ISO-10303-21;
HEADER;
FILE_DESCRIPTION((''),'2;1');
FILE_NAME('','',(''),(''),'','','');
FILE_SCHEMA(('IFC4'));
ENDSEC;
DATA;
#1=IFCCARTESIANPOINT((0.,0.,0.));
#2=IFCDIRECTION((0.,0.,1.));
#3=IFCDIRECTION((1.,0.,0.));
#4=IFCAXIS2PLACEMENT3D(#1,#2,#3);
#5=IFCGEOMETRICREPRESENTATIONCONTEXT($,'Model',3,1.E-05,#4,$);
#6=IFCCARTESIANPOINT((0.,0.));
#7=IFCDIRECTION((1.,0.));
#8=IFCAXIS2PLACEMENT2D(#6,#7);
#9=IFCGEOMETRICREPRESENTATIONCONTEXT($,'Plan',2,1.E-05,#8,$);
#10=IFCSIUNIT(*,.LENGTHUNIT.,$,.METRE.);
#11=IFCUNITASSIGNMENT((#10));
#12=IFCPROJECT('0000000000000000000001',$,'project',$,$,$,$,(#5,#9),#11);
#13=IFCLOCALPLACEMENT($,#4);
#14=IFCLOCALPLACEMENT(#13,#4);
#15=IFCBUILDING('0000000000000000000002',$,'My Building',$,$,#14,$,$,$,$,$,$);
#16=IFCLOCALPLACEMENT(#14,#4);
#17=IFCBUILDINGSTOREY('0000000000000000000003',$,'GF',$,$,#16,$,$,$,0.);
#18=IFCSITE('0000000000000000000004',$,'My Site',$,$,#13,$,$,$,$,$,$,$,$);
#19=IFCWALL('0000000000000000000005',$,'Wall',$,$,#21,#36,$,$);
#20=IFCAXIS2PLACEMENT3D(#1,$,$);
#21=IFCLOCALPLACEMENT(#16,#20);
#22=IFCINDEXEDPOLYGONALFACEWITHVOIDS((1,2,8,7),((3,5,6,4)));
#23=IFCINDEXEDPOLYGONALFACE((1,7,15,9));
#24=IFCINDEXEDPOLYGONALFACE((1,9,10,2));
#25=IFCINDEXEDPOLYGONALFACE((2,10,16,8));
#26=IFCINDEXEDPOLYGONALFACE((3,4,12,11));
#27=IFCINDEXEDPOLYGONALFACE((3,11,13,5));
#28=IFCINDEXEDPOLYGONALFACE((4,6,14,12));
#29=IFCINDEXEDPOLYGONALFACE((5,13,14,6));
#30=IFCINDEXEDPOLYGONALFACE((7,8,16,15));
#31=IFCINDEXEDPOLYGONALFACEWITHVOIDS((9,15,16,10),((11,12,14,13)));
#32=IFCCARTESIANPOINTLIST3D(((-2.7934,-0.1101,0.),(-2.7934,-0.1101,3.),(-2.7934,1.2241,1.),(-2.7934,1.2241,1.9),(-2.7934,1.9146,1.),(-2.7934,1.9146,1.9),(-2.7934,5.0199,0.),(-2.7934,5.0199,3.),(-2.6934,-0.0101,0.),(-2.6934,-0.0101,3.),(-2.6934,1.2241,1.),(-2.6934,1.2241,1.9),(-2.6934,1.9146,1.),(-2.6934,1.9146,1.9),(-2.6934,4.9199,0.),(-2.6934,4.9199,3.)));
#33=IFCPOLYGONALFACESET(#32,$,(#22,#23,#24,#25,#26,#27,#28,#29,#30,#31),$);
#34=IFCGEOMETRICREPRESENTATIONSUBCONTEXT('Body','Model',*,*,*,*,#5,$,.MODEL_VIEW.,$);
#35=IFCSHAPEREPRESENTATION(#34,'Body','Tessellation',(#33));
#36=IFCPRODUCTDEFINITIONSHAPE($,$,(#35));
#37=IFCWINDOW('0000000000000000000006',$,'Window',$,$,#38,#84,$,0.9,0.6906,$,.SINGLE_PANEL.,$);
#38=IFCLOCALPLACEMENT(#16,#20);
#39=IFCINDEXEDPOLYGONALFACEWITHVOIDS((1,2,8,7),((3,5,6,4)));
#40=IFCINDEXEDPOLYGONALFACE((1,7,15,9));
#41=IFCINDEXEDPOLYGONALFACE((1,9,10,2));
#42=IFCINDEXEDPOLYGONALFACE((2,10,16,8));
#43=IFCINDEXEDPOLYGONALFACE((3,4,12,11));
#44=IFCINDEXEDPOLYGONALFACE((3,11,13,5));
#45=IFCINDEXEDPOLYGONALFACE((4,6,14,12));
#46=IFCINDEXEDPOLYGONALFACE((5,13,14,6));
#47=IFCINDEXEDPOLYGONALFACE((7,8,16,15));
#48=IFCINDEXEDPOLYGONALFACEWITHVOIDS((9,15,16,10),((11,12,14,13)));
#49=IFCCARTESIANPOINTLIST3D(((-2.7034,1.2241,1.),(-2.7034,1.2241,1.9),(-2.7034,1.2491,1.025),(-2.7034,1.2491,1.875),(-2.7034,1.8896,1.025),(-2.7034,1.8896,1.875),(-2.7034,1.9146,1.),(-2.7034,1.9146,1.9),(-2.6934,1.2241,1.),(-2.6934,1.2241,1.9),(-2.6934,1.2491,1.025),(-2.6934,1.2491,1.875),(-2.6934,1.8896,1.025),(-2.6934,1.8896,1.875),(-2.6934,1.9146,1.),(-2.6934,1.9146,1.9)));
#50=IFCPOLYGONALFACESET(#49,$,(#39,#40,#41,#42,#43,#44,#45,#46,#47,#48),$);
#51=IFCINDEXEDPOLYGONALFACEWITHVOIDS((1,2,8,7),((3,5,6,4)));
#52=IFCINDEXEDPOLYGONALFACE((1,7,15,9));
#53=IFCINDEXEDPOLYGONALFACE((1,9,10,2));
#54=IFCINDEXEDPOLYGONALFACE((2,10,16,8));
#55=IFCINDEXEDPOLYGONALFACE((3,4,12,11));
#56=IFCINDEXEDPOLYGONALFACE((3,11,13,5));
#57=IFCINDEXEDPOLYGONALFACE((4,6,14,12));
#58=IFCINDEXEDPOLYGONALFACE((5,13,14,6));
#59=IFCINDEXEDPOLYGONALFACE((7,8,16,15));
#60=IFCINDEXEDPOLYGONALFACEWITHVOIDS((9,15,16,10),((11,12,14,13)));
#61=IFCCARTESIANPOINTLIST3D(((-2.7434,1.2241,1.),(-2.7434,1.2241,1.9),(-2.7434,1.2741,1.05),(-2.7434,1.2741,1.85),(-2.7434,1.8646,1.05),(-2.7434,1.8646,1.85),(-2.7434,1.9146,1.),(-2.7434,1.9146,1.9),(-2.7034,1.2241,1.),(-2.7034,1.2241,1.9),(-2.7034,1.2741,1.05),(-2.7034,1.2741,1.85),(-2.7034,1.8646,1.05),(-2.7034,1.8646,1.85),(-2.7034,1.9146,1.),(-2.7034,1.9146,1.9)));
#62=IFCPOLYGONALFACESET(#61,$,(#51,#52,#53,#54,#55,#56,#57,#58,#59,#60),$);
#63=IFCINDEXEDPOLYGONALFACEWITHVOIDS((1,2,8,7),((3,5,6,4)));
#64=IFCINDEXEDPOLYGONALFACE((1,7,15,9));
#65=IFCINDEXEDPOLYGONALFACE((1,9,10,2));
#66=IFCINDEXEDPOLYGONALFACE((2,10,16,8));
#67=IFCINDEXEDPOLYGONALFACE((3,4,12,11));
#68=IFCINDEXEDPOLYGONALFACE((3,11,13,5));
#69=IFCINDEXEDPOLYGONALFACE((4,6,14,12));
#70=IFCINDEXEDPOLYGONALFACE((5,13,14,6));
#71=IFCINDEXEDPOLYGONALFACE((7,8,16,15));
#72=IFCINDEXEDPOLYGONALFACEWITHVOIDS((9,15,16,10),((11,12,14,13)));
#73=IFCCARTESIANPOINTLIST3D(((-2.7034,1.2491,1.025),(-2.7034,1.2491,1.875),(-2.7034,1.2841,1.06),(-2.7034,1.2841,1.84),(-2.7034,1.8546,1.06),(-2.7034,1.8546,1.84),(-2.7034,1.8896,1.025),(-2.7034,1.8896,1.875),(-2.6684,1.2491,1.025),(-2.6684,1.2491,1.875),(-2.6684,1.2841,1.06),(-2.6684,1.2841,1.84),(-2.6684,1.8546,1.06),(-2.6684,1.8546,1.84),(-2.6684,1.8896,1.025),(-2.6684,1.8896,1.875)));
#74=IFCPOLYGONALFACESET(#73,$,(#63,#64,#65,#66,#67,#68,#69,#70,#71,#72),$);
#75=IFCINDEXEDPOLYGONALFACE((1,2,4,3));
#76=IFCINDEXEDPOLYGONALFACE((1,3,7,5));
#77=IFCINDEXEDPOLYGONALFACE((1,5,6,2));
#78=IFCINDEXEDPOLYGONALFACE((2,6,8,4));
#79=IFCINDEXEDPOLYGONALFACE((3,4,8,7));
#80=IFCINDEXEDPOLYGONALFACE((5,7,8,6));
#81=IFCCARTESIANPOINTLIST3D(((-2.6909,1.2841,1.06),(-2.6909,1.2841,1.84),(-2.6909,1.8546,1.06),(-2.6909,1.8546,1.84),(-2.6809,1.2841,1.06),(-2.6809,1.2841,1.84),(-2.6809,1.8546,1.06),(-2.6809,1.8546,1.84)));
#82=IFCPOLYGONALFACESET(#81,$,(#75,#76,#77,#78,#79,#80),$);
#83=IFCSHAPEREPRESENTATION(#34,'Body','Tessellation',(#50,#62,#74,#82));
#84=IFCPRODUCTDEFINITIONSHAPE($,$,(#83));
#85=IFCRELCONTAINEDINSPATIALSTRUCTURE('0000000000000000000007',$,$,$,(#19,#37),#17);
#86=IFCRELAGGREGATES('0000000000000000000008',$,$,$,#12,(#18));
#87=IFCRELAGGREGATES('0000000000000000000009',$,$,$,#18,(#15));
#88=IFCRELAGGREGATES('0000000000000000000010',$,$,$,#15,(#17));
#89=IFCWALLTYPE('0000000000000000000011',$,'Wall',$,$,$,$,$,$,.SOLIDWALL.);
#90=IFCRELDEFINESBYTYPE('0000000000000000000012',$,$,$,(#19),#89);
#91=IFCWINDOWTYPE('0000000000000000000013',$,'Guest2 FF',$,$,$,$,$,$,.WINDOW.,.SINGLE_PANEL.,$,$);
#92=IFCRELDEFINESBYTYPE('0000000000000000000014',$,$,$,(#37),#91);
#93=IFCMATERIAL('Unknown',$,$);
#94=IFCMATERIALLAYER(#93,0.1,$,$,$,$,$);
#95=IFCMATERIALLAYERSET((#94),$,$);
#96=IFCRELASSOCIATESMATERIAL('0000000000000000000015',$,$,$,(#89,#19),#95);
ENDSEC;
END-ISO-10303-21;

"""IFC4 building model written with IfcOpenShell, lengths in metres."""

from ifc_helpers import new_model, entity, si_unit, frame, origin_with_axes, origin_2d_with_axis, place, context, subcontext, project, spatial, line, indexed_curve, outline, extrude, shape, source, transform, mapped, material, layer, layer_set, layer_usage, type_object, type_shapes, element, fill, save


model = new_model("IFC4")

# Units and contexts
model_context = context("Model", 3, precision=1e-05, world=origin_with_axes())
plan_context = context("Plan", 2, precision=1e-05, world=origin_2d_with_axis())
body_context_1 = subcontext(model_context, "Body", "Model", "MODEL_VIEW")
body_context_2 = subcontext(plan_context, "Body", "Plan", "PLAN_VIEW")
ifc_project = project(units=[si_unit("LENGTHUNIT", "METRE")], contexts=[model_context, plan_context])

# Site, building, storey
site_placement = place(None, origin_with_axes())
site = spatial("IfcSite", under=ifc_project, at=site_placement, Name="My Site")
building_placement = place(site_placement, origin_with_axes())
building = spatial("IfcBuilding", under=site, at=building_placement, Name="My Building")
storey_placement = place(building_placement, origin_with_axes())
storey = spatial("IfcBuildingStorey", under=building, at=storey_placement, Name="GF", Elevation=0.0)

# Shared definitions
ifc_material = material(Name="Unknown")

# Shared definitions
ifc_layer_1 = layer(ifc_material, 0.1)
ifc_layer_set_1 = layer_set([ifc_layer_1])
wall_type = type_object("IfcWallType", Name="Wall", PredefinedType="SOLIDWALL", material=ifc_layer_set_1)

# Wall, opening, window
ifc_layer_usage_1 = layer_usage(ifc_layer_set_1, "AXIS2", "POSITIVE", 0.0)
wall_1_placement = place(storey_placement, frame((-2.7934, 5.0199, 0.0), z_axis=(0.0, 0.0, 1.0), x_axis=(0.0, -1.0, 0.0)))
wall_1 = element("IfcWall", 1, at=wall_1_placement, inside=storey, type_object=wall_type, material=ifc_layer_usage_1, Name="Wall", context=body_context_1, shape_type="SweptSolid", body=[
    extrude(outline(indexed_curve([(0.0, 0.0), (0.1, 0.1), (5.03, 0.1), (5.13, 0.0)], segments=[line(1, 2, 3, 4, 1)])), origin_with_axes(), (0.0, 0.0, 1.0), 3.0),
])
shared_shape_1 = source(origin_with_axes(), body_context_1, "Body", "SweptSolid", [
    extrude(outline(indexed_curve([(0.0, 0.0), (0.6906, 0.0), (0.6906, 0.9), (0.0, 0.9)], segments=[line(1, 2, 3, 4, 1)])), frame((0.0, -0.6, 0.0), z_axis=(0.0, -1.0, 0.0), x_axis=(1.0, 0.0, 0.0)), (0.0, 0.0, -1.0), 1.2),
])
opening_1_placement = place(wall_1_placement, frame((3.1053, 0.0, 1.0), z_axis=(0.0, 0.0, 1.0), x_axis=(1.0, 0.0, 0.0)))
opening_1 = element("IfcOpeningElement", 2, at=opening_1_placement, cuts=wall_1, PredefinedType="OPENING", context=body_context_1, shape_type="MappedRepresentation", body=[
    mapped(shared_shape_1, transform((0.0, 0.0, 0.0), x_axis=(1.0, 0.0, 0.0), y_axis=(0.0, 1.0, 0.0), z_axis=(0.0, 0.0, 1.0), scale=1.0)),
])
window_type_1 = type_object("IfcWindowType", Name="Guest2 FF", PartitioningType="SINGLE_PANEL", PredefinedType="WINDOW")
shared_shape_2 = source(origin_with_axes(), body_context_1, "Body", "SweptSolid", [
    extrude(outline(indexed_curve([(0.0, 0.0), (0.6906, 0.0), (0.6906, 0.9), (0.0, 0.9)], segments=[line(1, 2, 3, 4, 1)]), holes=[indexed_curve([(0.025, 0.025), (0.6656, 0.025), (0.6656, 0.875), (0.025, 0.875)], segments=[line(1, 2, 3, 4, 1)])]), frame((0.0, 0.09, 0.0), z_axis=(0.0, -1.0, 0.0), x_axis=(1.0, 0.0, 0.0)), (0.0, 0.0, -1.0), 0.01),
    extrude(outline(indexed_curve([(0.0, 0.0), (0.6906, 0.0), (0.6906, 0.9), (0.0, 0.9)], segments=[line(1, 2, 3, 4, 1)]), holes=[indexed_curve([(0.05, 0.05), (0.6406, 0.05), (0.6406, 0.85), (0.05, 0.85)], segments=[line(1, 2, 3, 4, 1)])]), frame((0.0, 0.05, 0.0), z_axis=(0.0, -1.0, 0.0), x_axis=(1.0, 0.0, 0.0)), (0.0, 0.0, -1.0), 0.04),
    extrude(outline(indexed_curve([(0.0, 0.0), (0.6406, 0.0), (0.6406, 0.85), (0.0, 0.85)], segments=[line(1, 2, 3, 4, 1)]), holes=[indexed_curve([(0.035, 0.035), (0.6056, 0.035), (0.6056, 0.815), (0.035, 0.815)], segments=[line(1, 2, 3, 4, 1)])]), frame((0.025, 0.09, 0.025), z_axis=(0.0, -1.0, 0.0), x_axis=(1.0, 0.0, 0.0)), (0.0, 0.0, -1.0), 0.035),
    extrude(outline(indexed_curve([(0.035, 0.035), (0.6056, 0.035), (0.6056, 0.815), (0.035, 0.815)], segments=[line(1, 2, 3, 4, 1)])), frame((0.025, 0.1025, 0.025), z_axis=(0.0, -1.0, 0.0), x_axis=(1.0, 0.0, 0.0)), (0.0, 0.0, -1.0), 0.01),
])
shared_shape_3 = source(origin_with_axes(), body_context_2, "Body", "Curve2D", [
    entity("IfcIndexedPolyCurve", entity("IfcCartesianPointList2D", [[0.05, 0.05], [0.6406, 0.05]])),
    entity("IfcIndexedPolyCurve", entity("IfcCartesianPointList2D", [[0.0, 0.1], [0.025, 0.1], [0.025, 0.09], [0.05, 0.09], [0.05, 0.05], [0.0, 0.05]]), [entity("IfcLineIndex", [1, 2, 3, 4, 5, 6, 1])]),
    entity("IfcIndexedPolyCurve", entity("IfcCartesianPointList2D", [[0.6906, 0.1], [0.6656, 0.1], [0.6656, 0.09], [0.6406, 0.09], [0.6406, 0.05], [0.6906, 0.05]]), [entity("IfcLineIndex", [1, 2, 3, 4, 5, 6, 1])]),
    entity("IfcIndexedPolyCurve", entity("IfcCartesianPointList2D", [[0.025, 0.09], [0.06, 0.09], [0.06, 0.125], [0.025, 0.125]]), [entity("IfcLineIndex", [1, 2, 3, 4, 1])]),
    entity("IfcIndexedPolyCurve", entity("IfcCartesianPointList2D", [[0.6656, 0.09], [0.6306, 0.09], [0.6306, 0.125], [0.6656, 0.125]]), [entity("IfcLineIndex", [1, 2, 3, 4, 1])]),
    entity("IfcIndexedPolyCurve", entity("IfcCartesianPointList2D", [[0.06, 0.09], [0.6306, 0.09]])),
    entity("IfcIndexedPolyCurve", entity("IfcCartesianPointList2D", [[0.06, 0.125], [0.6306, 0.125]])),
    entity("IfcIndexedPolyCurve", entity("IfcCartesianPointList2D", [[0.06, 0.1075], [0.6306, 0.1075]])),
])
type_shapes(window_type_1, [shared_shape_2, shared_shape_3])
window_1_placement = place(opening_1_placement, frame((0.0, 0.0, 0.0), z_axis=(0.0, 0.0, 1.0), x_axis=(1.0, 0.0, 0.0)))
window_1 = element("IfcWindow", 3, at=window_1_placement, inside=storey, type_object=window_type_1, Name="Window", OverallHeight=0.9, OverallWidth=0.6906, PartitioningType="SINGLE_PANEL", shapes=[
    shape(body_context_1, "Body", "MappedRepresentation", [mapped(shared_shape_2, transform((0.0, 0.0, 0.0), x_axis=(1.0, 0.0, 0.0), y_axis=(0.0, 1.0, 0.0), z_axis=(0.0, 0.0, 1.0), scale=1.0))]),
    shape(body_context_2, "Body", "MappedRepresentation", [mapped(shared_shape_3, transform((0.0, 0.0, 0.0), x_axis=(1.0, 0.0, 0.0), y_axis=(0.0, 1.0, 0.0), z_axis=(0.0, 0.0, 1.0), scale=1.0))]),
])
fill(opening_1, window_1)

save(model, "model.ifc")
